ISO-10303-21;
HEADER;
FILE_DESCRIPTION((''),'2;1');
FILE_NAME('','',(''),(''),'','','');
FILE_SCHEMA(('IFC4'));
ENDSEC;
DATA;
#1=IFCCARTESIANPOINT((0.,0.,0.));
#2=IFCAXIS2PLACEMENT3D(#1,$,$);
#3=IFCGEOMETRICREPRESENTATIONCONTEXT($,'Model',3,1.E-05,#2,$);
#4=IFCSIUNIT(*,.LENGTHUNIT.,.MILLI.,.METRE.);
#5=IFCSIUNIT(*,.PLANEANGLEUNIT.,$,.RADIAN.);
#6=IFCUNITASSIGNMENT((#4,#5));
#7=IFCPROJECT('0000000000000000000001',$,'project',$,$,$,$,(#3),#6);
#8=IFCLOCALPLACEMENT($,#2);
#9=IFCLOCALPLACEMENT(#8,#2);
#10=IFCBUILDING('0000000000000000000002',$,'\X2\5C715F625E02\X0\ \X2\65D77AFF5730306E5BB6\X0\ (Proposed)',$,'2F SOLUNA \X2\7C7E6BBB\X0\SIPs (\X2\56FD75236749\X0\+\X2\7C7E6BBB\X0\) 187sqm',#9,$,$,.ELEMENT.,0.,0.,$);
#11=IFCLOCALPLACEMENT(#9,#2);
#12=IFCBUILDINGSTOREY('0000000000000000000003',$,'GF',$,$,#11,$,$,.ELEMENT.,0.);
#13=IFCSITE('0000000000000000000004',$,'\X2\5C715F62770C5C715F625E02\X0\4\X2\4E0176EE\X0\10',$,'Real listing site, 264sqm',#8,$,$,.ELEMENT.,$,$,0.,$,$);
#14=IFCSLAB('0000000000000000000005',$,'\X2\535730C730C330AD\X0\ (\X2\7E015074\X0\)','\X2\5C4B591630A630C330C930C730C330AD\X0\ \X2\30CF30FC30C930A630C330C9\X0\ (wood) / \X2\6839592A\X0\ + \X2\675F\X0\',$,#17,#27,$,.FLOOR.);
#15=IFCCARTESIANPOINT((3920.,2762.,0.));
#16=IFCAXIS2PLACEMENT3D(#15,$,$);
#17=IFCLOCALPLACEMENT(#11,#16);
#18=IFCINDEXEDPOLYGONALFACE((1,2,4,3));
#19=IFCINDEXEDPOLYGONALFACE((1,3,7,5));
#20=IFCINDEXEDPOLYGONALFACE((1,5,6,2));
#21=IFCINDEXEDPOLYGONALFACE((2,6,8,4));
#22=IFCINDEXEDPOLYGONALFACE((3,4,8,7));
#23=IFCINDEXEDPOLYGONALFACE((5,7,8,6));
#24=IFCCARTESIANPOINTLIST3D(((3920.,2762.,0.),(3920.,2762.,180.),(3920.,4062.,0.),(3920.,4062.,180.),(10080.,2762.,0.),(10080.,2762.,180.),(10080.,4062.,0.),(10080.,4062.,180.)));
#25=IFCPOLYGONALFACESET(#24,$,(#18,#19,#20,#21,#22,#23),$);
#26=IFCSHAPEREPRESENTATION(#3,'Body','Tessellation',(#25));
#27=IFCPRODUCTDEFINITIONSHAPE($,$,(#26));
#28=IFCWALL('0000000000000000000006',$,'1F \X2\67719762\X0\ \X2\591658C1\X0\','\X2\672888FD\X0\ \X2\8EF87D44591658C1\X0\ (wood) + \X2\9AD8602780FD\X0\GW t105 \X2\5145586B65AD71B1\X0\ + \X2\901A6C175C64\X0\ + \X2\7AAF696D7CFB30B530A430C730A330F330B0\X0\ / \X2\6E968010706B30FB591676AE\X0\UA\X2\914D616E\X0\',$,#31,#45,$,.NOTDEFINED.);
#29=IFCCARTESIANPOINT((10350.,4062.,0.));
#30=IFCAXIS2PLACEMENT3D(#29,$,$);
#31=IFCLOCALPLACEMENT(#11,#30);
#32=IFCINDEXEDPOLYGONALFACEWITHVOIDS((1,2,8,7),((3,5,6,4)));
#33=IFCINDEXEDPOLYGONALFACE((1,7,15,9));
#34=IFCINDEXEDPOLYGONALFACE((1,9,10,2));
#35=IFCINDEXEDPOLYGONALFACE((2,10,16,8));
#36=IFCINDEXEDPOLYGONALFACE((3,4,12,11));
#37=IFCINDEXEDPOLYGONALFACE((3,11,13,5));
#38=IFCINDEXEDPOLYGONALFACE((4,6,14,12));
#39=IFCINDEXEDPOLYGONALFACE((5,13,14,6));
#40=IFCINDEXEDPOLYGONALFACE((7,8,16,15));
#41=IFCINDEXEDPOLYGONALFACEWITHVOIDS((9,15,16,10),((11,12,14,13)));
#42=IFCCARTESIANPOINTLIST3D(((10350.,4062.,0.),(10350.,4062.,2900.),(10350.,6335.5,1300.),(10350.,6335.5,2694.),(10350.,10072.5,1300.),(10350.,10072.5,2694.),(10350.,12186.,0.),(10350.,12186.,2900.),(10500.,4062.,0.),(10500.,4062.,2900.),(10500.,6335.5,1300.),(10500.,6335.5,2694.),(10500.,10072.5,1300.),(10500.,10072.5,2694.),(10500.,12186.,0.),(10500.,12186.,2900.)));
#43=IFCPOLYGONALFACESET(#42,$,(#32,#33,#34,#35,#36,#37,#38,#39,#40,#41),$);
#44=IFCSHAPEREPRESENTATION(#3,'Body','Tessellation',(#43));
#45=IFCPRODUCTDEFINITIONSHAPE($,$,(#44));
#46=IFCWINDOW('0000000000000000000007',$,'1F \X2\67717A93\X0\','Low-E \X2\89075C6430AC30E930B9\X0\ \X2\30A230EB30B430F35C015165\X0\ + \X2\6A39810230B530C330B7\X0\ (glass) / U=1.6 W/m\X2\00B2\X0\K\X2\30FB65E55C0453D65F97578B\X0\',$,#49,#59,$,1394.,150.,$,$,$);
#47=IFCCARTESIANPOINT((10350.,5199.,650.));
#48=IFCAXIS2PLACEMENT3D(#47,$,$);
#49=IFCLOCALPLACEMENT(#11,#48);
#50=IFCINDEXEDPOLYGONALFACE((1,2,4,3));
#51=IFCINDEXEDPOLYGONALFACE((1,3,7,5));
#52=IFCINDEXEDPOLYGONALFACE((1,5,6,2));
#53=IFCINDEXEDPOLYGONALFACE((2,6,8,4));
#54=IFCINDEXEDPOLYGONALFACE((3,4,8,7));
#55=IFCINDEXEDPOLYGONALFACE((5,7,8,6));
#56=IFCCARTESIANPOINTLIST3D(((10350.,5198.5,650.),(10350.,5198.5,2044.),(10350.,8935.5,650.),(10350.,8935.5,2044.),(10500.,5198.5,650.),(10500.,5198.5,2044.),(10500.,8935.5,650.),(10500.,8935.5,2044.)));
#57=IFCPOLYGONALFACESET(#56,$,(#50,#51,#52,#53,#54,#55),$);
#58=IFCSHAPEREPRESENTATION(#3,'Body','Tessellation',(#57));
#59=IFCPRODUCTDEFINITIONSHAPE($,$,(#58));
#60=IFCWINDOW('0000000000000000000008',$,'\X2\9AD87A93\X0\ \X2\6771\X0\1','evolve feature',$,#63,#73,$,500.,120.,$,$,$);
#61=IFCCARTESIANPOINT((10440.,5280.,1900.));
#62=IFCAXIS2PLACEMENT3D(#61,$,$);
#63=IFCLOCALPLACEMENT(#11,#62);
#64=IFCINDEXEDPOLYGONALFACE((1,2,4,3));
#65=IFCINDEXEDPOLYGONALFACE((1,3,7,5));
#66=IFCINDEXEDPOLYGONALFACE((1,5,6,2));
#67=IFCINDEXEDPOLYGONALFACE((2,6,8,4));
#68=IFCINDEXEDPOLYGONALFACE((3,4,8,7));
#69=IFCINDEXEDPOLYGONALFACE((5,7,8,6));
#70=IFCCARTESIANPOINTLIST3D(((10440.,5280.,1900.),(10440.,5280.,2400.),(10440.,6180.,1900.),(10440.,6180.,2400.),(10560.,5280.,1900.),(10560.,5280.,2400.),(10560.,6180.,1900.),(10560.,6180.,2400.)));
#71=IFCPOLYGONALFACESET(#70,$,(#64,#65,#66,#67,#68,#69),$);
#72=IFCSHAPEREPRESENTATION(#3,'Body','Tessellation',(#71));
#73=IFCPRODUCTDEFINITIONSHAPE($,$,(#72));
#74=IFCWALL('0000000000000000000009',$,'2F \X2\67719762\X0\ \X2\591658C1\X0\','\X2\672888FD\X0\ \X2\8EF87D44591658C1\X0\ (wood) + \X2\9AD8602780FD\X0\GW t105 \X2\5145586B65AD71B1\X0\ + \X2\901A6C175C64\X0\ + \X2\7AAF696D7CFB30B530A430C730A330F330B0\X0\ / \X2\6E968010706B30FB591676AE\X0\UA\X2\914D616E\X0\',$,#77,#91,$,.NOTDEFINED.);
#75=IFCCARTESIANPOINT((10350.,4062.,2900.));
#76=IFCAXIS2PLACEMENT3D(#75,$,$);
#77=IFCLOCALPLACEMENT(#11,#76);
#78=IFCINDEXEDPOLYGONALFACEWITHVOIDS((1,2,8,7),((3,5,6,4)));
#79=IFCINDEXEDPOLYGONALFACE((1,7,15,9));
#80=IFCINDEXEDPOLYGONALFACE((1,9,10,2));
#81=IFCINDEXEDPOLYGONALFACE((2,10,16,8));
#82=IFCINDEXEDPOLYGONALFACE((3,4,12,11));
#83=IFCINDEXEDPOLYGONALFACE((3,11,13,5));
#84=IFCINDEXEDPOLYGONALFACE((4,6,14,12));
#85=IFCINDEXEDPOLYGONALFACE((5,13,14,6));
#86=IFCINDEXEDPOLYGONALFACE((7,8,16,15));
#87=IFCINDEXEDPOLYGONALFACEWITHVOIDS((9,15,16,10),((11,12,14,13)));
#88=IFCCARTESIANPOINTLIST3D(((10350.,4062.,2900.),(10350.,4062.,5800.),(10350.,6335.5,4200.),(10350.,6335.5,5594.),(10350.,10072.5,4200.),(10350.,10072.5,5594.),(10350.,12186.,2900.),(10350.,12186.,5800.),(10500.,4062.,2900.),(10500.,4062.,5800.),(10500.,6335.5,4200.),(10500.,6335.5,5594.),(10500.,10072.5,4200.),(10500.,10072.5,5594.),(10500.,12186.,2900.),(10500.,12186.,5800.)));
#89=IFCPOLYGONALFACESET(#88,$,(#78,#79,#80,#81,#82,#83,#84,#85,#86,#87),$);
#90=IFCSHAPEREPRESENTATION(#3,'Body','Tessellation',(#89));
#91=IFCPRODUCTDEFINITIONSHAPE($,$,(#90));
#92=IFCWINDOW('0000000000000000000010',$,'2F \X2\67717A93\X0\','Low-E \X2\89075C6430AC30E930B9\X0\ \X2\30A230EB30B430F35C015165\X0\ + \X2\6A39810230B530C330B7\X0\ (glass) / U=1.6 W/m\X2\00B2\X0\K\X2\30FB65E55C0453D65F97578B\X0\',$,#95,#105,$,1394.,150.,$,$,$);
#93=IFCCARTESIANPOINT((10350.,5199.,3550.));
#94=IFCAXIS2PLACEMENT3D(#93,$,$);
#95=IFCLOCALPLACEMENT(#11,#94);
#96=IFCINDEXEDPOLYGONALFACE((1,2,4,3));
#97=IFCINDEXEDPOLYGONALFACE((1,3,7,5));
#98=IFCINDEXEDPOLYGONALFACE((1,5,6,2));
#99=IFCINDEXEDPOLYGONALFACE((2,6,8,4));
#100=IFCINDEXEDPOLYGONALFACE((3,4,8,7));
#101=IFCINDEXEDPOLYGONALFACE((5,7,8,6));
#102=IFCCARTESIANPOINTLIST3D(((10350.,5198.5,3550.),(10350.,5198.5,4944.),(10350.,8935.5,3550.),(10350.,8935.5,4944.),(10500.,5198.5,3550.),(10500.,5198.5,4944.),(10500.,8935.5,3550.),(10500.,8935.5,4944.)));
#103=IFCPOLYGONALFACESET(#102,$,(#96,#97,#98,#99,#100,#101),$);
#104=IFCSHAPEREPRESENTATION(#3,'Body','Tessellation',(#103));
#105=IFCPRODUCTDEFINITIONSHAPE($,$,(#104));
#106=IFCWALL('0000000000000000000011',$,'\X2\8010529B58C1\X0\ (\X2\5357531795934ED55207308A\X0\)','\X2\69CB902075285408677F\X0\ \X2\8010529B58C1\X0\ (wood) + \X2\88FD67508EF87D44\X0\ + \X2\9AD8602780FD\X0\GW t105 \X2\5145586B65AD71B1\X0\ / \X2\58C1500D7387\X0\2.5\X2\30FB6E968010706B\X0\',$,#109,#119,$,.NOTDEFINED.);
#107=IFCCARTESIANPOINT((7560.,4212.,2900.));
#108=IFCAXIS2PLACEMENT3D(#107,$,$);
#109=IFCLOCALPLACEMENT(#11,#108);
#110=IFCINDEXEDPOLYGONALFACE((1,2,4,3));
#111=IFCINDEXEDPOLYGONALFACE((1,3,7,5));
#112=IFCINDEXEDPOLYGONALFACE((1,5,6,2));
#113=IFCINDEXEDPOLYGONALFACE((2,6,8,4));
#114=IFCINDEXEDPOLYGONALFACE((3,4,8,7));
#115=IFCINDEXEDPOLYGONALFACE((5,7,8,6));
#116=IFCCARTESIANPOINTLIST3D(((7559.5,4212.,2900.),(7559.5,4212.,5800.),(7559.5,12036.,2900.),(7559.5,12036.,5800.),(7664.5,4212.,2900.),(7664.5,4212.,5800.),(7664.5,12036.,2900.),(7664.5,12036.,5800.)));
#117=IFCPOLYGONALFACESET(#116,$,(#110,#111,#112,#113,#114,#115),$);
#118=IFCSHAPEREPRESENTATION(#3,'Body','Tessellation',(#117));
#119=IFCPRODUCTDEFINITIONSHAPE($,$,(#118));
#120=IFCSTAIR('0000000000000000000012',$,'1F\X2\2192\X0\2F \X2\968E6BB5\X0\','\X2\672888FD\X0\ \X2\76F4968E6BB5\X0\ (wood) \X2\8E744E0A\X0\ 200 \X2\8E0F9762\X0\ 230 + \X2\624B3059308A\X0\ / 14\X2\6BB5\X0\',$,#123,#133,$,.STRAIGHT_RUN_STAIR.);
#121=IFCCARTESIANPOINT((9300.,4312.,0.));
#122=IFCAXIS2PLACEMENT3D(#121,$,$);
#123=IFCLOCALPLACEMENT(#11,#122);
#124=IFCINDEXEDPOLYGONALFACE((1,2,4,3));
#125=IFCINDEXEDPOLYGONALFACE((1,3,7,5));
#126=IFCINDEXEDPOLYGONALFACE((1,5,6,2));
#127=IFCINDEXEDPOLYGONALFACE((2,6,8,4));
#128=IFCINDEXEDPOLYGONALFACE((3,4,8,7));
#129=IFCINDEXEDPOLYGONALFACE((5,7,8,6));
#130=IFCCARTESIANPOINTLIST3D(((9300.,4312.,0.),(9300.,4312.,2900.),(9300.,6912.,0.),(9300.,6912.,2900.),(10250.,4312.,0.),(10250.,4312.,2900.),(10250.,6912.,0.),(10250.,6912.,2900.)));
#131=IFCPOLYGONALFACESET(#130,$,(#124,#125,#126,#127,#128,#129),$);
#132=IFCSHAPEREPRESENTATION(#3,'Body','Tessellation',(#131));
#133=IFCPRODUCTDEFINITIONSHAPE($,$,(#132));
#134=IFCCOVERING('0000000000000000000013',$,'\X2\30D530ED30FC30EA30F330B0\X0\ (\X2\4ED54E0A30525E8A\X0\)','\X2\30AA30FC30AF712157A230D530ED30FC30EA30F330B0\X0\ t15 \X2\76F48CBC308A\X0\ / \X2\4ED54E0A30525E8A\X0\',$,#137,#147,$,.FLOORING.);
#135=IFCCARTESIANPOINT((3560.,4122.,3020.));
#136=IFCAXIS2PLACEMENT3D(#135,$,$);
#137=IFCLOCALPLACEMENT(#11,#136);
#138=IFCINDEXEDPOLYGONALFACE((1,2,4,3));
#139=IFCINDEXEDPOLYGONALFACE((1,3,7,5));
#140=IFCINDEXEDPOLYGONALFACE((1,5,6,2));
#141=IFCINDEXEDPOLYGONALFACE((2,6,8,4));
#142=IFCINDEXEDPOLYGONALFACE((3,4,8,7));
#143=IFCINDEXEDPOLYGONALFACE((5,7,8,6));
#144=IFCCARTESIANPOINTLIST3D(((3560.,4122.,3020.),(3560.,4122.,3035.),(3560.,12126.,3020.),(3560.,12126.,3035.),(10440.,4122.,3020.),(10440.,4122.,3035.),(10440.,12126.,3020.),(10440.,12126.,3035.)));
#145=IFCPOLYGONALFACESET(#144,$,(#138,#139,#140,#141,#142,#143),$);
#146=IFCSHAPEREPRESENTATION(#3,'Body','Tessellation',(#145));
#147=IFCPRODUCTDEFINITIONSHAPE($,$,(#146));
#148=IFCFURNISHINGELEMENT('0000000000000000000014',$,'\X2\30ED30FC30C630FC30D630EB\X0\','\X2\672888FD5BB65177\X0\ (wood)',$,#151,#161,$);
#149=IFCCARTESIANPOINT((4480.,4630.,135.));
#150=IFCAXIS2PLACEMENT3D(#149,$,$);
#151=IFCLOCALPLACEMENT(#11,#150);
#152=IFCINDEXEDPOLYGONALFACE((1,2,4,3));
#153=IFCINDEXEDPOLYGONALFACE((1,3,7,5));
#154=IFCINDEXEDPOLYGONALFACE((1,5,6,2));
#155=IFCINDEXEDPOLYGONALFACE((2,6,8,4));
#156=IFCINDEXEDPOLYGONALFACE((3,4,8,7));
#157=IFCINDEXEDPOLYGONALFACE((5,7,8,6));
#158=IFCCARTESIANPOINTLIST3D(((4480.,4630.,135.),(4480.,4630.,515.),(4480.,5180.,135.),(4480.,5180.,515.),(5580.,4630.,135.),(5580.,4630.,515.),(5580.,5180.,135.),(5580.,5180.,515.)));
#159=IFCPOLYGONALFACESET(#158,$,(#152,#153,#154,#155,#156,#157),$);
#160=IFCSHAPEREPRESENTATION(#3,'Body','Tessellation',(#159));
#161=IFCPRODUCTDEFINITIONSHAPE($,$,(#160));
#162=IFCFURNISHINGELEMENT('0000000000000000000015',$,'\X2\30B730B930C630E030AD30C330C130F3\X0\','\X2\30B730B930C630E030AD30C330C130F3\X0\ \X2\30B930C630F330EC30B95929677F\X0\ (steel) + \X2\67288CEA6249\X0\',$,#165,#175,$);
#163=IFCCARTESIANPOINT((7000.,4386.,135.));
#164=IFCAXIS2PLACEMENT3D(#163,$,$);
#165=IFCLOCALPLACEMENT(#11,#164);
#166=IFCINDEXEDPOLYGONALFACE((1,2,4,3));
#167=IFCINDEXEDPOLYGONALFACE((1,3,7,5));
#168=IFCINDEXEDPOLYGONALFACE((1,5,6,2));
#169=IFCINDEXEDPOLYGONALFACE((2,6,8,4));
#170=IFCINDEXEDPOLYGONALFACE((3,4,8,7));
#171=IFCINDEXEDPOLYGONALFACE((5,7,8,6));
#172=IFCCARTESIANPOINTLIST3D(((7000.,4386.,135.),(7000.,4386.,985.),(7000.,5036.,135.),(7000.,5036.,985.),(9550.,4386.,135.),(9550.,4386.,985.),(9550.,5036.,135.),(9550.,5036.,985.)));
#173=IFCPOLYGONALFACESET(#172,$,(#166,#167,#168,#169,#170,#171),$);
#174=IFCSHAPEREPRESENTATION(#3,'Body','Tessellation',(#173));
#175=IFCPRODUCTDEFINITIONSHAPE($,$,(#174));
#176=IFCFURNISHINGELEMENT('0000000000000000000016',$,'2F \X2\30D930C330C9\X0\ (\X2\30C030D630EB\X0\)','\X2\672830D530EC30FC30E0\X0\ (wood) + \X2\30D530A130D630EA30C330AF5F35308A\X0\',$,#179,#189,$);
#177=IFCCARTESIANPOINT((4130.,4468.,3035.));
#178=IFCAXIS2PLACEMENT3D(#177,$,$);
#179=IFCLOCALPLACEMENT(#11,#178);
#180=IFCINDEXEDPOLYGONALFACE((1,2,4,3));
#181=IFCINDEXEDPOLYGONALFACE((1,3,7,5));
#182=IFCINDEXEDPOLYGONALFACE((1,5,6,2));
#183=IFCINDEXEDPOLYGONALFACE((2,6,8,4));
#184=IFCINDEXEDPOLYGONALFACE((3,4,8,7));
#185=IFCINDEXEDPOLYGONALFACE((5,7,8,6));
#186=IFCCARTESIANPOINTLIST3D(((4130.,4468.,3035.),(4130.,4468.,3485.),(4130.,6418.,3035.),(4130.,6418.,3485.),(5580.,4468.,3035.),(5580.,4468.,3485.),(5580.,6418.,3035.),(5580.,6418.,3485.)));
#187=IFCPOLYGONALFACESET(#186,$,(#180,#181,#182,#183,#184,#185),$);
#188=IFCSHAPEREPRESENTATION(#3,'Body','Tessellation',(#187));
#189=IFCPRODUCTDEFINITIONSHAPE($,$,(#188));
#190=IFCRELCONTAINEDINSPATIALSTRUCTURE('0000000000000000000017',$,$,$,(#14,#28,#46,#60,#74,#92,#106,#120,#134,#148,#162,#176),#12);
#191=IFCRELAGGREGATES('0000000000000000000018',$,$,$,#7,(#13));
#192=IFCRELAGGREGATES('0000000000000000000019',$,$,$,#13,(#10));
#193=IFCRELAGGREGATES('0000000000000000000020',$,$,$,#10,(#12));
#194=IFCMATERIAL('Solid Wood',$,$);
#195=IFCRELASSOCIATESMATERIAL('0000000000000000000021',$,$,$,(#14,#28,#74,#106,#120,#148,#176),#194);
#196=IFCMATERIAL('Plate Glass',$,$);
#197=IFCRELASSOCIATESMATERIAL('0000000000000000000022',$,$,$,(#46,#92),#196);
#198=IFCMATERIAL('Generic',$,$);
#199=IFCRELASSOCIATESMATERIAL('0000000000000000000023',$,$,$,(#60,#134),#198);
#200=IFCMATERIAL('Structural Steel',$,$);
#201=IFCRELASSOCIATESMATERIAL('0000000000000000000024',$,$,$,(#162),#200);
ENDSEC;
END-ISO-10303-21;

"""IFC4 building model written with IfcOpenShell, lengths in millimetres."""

from ifc_helpers import new_model, si_unit, frame, frame_2d, origin, place, context, project, spatial, rectangle, extrude, material, element, fill, save


model = new_model("IFC4")

# Units and contexts
model_context = context("Model", 3, precision=1e-05, world=origin())
ifc_project = project(units=[si_unit("LENGTHUNIT", "METRE", prefix="MILLI"), si_unit("PLANEANGLEUNIT", "RADIAN")], contexts=[model_context])

# Site, building, storey
site_placement = place(None, origin())
site = spatial("IfcSite", under=ifc_project, at=site_placement, Name="山形県山形市4丁目10", ObjectType="Real listing site, 264sqm", CompositionType="ELEMENT", RefElevation=0.0)
building_placement = place(site_placement, origin())
building = spatial("IfcBuilding", under=site, at=building_placement, Name="山形市 旗竿地の家 (Proposed)", ObjectType="2F SOLUNA 籾殻SIPs (国産杉+籾殻) 187sqm", CompositionType="ELEMENT", ElevationOfRefHeight=0.0, ElevationOfTerrain=0.0)
storey_placement = place(building_placement, origin())
storey = spatial("IfcBuildingStorey", under=building, at=storey_placement, Name="GF", CompositionType="ELEMENT", Elevation=0.0)

# Slab
ifc_material_1 = material(Name="Solid Wood")
slab_placement = place(storey_placement, frame((3920.0, 2762.0, 0.0)))
element("IfcSlab", 1, at=slab_placement, inside=storey, material=ifc_material_1, Name="南デッキ (縁側)", Description="屋外ウッドデッキ ハードウッド (wood) / 根太 + 束", PredefinedType="FLOOR", context=model_context, shape_type="SweptSolid", body=[
    extrude(rectangle(XDim=6160.0, YDim=1300.0, at=frame_2d((3080.0, 650.0))), frame((3920.0, 2762.0, 0.0)), (0.0, 0.0, 1.0), 180.0),
])

# Wall, openings, windows
wall_1_placement = place(storey_placement, frame((10350.0, 4062.0, 0.0)))
wall_1 = element("IfcWall", 2, at=wall_1_placement, inside=storey, material=ifc_material_1, Name="1F 東面 外壁", Description="木製 軸組外壁 (wood) + 高性能GW t105 充填断熱 + 通気層 + 窯業系サイディング / 準耐火・外皮UA配慮", PredefinedType="NOTDEFINED", context=model_context, shape_type="SweptSolid", body=[
    extrude(rectangle(XDim=150.0, YDim=8124.0, at=frame_2d((75.0, 4062.0))), frame((10350.0, 4062.0, 0.0)), (0.0, 0.0, 1.0), 2900.0),
])
opening_1_placement = place(storey_placement, frame((10350.0, 5199.0, 650.0)))
opening_1 = element("IfcOpeningElement", 3, at=opening_1_placement, cuts=wall_1, PredefinedType="NOTDEFINED", context=model_context, shape_type="SweptSolid", body=[
    extrude(rectangle(XDim=150.0, YDim=3737.0, at=frame_2d((75.0, 1868.0))), frame((10350.0, 5199.0, 650.0)), (0.0, 0.0, 1.0), 1394.0),
])
opening_2_placement = place(storey_placement, frame((10440.0, 5280.0, 1900.0)))
opening_2 = element("IfcOpeningElement", 4, at=opening_2_placement, cuts=wall_1, PredefinedType="NOTDEFINED", context=model_context, shape_type="SweptSolid", body=[
    extrude(rectangle(XDim=120.0, YDim=900.0, at=frame_2d((60.0, 450.0))), frame((10440.0, 5280.0, 1900.0)), (0.0, 0.0, 1.0), 500.0),
])
ifc_material_2 = material(Name="Plate Glass")
window_1_placement = place(storey_placement, frame((10350.0, 5199.0, 650.0)))
window_1 = element("IfcWindow", 5, at=window_1_placement, inside=storey, material=ifc_material_2, Name="1F 東窓", Description="Low-E 複層ガラス アルゴン封入 + 樹脂サッシ (glass) / U=1.6 W/m²K・日射取得型", OverallHeight=1394.0, OverallWidth=150.0, context=model_context, shape_type="SweptSolid", body=[
    extrude(rectangle(XDim=150.0, YDim=3737.0, at=frame_2d((75.0, 1868.0))), frame((10350.0, 5199.0, 650.0)), (0.0, 0.0, 1.0), 1394.0),
])
fill(opening_1, window_1)
ifc_material_3 = material(Name="Generic")
window_2_placement = place(storey_placement, frame((10440.0, 5280.0, 1900.0)))
window_2 = element("IfcWindow", 6, at=window_2_placement, inside=storey, material=ifc_material_3, Name="高窓 東1", Description="evolve feature", OverallHeight=500.0, OverallWidth=120.0, context=model_context, shape_type="SweptSolid", body=[
    extrude(rectangle(XDim=120.0, YDim=900.0, at=frame_2d((60.0, 450.0))), frame((10440.0, 5280.0, 1900.0)), (0.0, 0.0, 1.0), 500.0),
])
fill(opening_2, window_2)

# Wall, opening, window
wall_2_placement = place(storey_placement, frame((10350.0, 4062.0, 2900.0)))
wall_2 = element("IfcWall", 7, at=wall_2_placement, inside=storey, material=ifc_material_1, Name="2F 東面 外壁", Description="木製 軸組外壁 (wood) + 高性能GW t105 充填断熱 + 通気層 + 窯業系サイディング / 準耐火・外皮UA配慮", PredefinedType="NOTDEFINED", context=model_context, shape_type="SweptSolid", body=[
    extrude(rectangle(XDim=150.0, YDim=8124.0, at=frame_2d((75.0, 4062.0))), frame((10350.0, 4062.0, 2900.0)), (0.0, 0.0, 1.0), 2900.0),
])
opening_3_placement = place(storey_placement, frame((10350.0, 5199.0, 3550.0)))
opening_3 = element("IfcOpeningElement", 8, at=opening_3_placement, cuts=wall_2, PredefinedType="NOTDEFINED", context=model_context, shape_type="SweptSolid", body=[
    extrude(rectangle(XDim=150.0, YDim=3737.0, at=frame_2d((75.0, 1868.0))), frame((10350.0, 5199.0, 3550.0)), (0.0, 0.0, 1.0), 1394.0),
])
window_3_placement = place(storey_placement, frame((10350.0, 5199.0, 3550.0)))
window_3 = element("IfcWindow", 9, at=window_3_placement, inside=storey, material=ifc_material_2, Name="2F 東窓", Description="Low-E 複層ガラス アルゴン封入 + 樹脂サッシ (glass) / U=1.6 W/m²K・日射取得型", OverallHeight=1394.0, OverallWidth=150.0, context=model_context, shape_type="SweptSolid", body=[
    extrude(rectangle(XDim=150.0, YDim=3737.0, at=frame_2d((75.0, 1868.0))), frame((10350.0, 5199.0, 3550.0)), (0.0, 0.0, 1.0), 1394.0),
])
fill(opening_3, window_3)

# Wall
wall_3_placement = place(storey_placement, frame((7560.0, 4212.0, 2900.0)))
element("IfcWall", 10, at=wall_3_placement, inside=storey, material=ifc_material_1, Name="耐力壁 (南北間仕切り)", Description="構造用合板 耐力壁 (wood) + 製材軸組 + 高性能GW t105 充填断熱 / 壁倍率2.5・準耐火", PredefinedType="NOTDEFINED", context=model_context, shape_type="SweptSolid", body=[
    extrude(rectangle(XDim=105.0, YDim=7824.0, at=frame_2d((52.0, 3912.0))), frame((7560.0, 4212.0, 2900.0)), (0.0, 0.0, 1.0), 2900.0),
])

# Stair
stair_placement = place(storey_placement, frame((9300.0, 4312.0, 0.0)))
element("IfcStair", 11, at=stair_placement, inside=storey, material=ifc_material_1, Name="1F→2F 階段", Description="木製 直階段 (wood) 蹴上 200 踏面 230 + 手すり / 14段", PredefinedType="STRAIGHT_RUN_STAIR", context=model_context, shape_type="SweptSolid", body=[
    extrude(rectangle(XDim=950.0, YDim=2600.0, at=frame_2d((475.0, 1300.0))), frame((9300.0, 4312.0, 0.0)), (0.0, 0.0, 1.0), 2900.0),
])

# Covering
covering_placement = place(storey_placement, frame((3560.0, 4122.0, 3020.0)))
element("IfcCovering", 12, at=covering_placement, inside=storey, material=ifc_material_3, Name="フローリング (仕上げ床)", Description="オーク無垢フローリング t15 直貼り / 仕上げ床", PredefinedType="FLOORING", context=model_context, shape_type="SweptSolid", body=[
    extrude(rectangle(XDim=6880.0, YDim=8004.0, at=frame_2d((3440.0, 4002.0))), frame((3560.0, 4122.0, 3020.0)), (0.0, 0.0, 1.0), 15.0),
])

# Furnishing elements
furnishing_1_placement = place(storey_placement, frame((4480.0, 4630.0, 135.0)))
element("IfcFurnishingElement", 13, at=furnishing_1_placement, inside=storey, material=ifc_material_1, Name="ローテーブル", Description="木製家具 (wood)", context=model_context, shape_type="SweptSolid", body=[
    extrude(rectangle(XDim=1100.0, YDim=550.0, at=frame_2d((550.0, 275.0))), frame((4480.0, 4630.0, 135.0)), (0.0, 0.0, 1.0), 380.0),
])
ifc_material_4 = material(Name="Structural Steel")
furnishing_2_placement = place(storey_placement, frame((7000.0, 4386.0, 135.0)))
element("IfcFurnishingElement", 14, at=furnishing_2_placement, inside=storey, material=ifc_material_4, Name="システムキッチン", Description="システムキッチン ステンレス天板 (steel) + 木質扉", context=model_context, shape_type="SweptSolid", body=[
    extrude(rectangle(XDim=2550.0, YDim=650.0, at=frame_2d((1275.0, 325.0))), frame((7000.0, 4386.0, 135.0)), (0.0, 0.0, 1.0), 850.0),
])
furnishing_3_placement = place(storey_placement, frame((4130.0, 4468.0, 3035.0)))
element("IfcFurnishingElement", 15, at=furnishing_3_placement, inside=storey, material=ifc_material_1, Name="2F ベッド (ダブル)", Description="木フレーム (wood) + ファブリック張り", context=model_context, shape_type="SweptSolid", body=[
    extrude(rectangle(XDim=1450.0, YDim=1950.0, at=frame_2d((725.0, 975.0))), frame((4130.0, 4468.0, 3035.0)), (0.0, 0.0, 1.0), 450.0),
])

save(model, "model.ifc")
